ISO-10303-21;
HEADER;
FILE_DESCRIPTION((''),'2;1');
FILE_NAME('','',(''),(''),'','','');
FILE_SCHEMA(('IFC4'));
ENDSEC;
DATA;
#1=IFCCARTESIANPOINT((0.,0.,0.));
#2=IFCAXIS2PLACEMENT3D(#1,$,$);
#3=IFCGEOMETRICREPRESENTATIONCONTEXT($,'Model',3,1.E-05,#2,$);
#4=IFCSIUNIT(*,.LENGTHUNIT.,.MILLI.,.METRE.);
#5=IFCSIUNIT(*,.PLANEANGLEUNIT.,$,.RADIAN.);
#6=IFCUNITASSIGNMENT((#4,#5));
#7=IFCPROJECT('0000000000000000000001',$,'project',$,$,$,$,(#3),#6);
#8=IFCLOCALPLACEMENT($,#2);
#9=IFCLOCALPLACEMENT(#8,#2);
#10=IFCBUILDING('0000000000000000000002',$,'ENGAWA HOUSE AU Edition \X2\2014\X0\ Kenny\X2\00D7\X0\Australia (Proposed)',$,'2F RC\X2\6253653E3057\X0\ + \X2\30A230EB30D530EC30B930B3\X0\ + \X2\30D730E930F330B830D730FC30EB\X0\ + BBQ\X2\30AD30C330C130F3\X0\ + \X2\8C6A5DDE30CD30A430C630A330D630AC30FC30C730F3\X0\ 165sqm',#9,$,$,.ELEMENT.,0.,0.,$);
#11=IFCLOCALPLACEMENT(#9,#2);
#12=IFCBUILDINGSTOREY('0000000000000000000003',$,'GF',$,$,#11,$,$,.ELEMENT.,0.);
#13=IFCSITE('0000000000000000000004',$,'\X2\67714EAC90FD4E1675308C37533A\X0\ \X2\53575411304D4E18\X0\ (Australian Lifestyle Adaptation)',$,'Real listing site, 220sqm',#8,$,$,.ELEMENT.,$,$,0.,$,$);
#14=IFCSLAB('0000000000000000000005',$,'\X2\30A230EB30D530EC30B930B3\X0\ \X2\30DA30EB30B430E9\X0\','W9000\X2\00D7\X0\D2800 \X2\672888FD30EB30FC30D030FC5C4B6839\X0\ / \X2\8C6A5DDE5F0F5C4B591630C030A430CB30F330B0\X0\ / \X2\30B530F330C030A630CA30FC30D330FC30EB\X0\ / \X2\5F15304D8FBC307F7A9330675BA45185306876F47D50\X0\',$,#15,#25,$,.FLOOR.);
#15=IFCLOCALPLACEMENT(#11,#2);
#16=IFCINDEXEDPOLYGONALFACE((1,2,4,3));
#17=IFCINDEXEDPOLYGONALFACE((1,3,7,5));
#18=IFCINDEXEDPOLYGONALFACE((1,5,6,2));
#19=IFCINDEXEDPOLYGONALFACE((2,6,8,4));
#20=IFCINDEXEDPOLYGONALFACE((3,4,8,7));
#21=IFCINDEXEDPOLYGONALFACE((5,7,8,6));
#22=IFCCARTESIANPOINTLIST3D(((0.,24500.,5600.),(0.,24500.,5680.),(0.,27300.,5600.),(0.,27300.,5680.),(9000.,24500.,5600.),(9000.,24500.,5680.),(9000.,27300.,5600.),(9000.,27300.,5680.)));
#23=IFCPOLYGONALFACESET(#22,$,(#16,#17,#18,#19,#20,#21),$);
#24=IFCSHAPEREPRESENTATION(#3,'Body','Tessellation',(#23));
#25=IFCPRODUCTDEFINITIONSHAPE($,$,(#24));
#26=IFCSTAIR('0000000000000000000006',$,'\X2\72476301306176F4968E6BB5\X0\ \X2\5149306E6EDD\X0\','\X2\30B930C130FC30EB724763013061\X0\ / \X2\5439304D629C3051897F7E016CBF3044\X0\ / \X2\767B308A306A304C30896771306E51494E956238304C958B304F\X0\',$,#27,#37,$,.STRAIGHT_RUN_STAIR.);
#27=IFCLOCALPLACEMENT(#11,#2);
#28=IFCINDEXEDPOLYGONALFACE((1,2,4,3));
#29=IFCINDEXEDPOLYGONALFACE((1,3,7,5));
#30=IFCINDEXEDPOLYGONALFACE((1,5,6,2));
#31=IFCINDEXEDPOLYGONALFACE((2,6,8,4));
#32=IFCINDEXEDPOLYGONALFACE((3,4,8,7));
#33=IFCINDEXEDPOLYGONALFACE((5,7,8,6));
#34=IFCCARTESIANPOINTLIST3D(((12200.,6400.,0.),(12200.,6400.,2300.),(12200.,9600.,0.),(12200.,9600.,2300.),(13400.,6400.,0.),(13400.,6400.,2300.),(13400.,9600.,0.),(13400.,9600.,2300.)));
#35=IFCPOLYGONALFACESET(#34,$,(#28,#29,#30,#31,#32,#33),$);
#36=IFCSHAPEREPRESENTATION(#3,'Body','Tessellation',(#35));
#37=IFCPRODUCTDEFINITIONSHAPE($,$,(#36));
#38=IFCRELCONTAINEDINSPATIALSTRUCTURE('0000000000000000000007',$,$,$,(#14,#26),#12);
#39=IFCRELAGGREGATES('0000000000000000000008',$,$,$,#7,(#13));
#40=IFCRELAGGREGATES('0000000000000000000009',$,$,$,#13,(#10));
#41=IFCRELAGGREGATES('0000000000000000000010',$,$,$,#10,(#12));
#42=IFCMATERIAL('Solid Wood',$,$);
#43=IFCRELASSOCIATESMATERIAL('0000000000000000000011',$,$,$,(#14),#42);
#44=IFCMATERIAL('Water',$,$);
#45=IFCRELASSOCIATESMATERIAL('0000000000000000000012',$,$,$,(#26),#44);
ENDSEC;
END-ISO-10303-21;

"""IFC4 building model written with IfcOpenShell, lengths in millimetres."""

from ifc_helpers import new_model, si_unit, frame, frame_2d, origin, place, context, project, spatial, rectangle, extrude, material, element, save


model = new_model("IFC4")

# Units and contexts
model_context = context("Model", 3, precision=1e-05, world=origin())
ifc_project = project(units=[si_unit("LENGTHUNIT", "METRE", prefix="MILLI"), si_unit("PLANEANGLEUNIT", "RADIAN")], contexts=[model_context])

# Site, building, storey
site_placement = place(None, origin())
site = spatial("IfcSite", under=ifc_project, at=site_placement, Name="東京都世田谷区 南向き丘 (Australian Lifestyle Adaptation)", ObjectType="Real listing site, 220sqm", CompositionType="ELEMENT", RefElevation=0.0)
building_placement = place(site_placement, origin())
building = spatial("IfcBuilding", under=site, at=building_placement, Name="ENGAWA HOUSE AU Edition — Kenny×Australia (Proposed)", ObjectType="2F RC打放し + アルフレスコ + プランジプール + BBQキッチン + 豪州ネイティブガーデン 165sqm", CompositionType="ELEMENT", ElevationOfRefHeight=0.0, ElevationOfTerrain=0.0)
storey_placement = place(building_placement, origin())
storey = spatial("IfcBuildingStorey", under=building, at=storey_placement, Name="GF", CompositionType="ELEMENT", Elevation=0.0)

# Slab
ifc_material_1 = material(Name="Solid Wood")
slab_1_placement = place(storey_placement, frame((0.0, 12250.0, 2800.0)))
element("IfcSlab", 1, at=slab_1_placement, inside=storey, material=ifc_material_1, Name="アルフレスコ ペルゴラ", Description="W9000×D2800 木製ルーバー屋根 / 豪州式屋外ダイニング / サンダウナービール / 引き込み窓で室内と直結", PredefinedType="FLOOR", context=model_context, shape_type="SweptSolid", body=[
    extrude(rectangle(XDim=9000.0, YDim=2800.0, at=frame_2d((4500.0, 1400.0))), frame((0.0, 12250.0, 2800.0)), (0.0, 0.0, 1.0), 80.0),
])

# Stair
ifc_material_2 = material(Name="Water")
stair_placement = place(storey_placement, frame((6100.0, 3200.0, 0.0)))
element("IfcStair", 2, at=stair_placement, inside=storey, material=ifc_material_2, Name="片持ち直階段 光の滝", Description="スチール片持ち / 吹き抜け西縁沿い / 登りながら東の光井戸が開く", PredefinedType="STRAIGHT_RUN_STAIR", context=model_context, shape_type="SweptSolid", body=[
    extrude(rectangle(XDim=1200.0, YDim=3200.0, at=frame_2d((600.0, 1600.0))), frame((6100.0, 3200.0, 0.0)), (0.0, 0.0, 1.0), 2300.0),
])

save(model, "model.ifc")
